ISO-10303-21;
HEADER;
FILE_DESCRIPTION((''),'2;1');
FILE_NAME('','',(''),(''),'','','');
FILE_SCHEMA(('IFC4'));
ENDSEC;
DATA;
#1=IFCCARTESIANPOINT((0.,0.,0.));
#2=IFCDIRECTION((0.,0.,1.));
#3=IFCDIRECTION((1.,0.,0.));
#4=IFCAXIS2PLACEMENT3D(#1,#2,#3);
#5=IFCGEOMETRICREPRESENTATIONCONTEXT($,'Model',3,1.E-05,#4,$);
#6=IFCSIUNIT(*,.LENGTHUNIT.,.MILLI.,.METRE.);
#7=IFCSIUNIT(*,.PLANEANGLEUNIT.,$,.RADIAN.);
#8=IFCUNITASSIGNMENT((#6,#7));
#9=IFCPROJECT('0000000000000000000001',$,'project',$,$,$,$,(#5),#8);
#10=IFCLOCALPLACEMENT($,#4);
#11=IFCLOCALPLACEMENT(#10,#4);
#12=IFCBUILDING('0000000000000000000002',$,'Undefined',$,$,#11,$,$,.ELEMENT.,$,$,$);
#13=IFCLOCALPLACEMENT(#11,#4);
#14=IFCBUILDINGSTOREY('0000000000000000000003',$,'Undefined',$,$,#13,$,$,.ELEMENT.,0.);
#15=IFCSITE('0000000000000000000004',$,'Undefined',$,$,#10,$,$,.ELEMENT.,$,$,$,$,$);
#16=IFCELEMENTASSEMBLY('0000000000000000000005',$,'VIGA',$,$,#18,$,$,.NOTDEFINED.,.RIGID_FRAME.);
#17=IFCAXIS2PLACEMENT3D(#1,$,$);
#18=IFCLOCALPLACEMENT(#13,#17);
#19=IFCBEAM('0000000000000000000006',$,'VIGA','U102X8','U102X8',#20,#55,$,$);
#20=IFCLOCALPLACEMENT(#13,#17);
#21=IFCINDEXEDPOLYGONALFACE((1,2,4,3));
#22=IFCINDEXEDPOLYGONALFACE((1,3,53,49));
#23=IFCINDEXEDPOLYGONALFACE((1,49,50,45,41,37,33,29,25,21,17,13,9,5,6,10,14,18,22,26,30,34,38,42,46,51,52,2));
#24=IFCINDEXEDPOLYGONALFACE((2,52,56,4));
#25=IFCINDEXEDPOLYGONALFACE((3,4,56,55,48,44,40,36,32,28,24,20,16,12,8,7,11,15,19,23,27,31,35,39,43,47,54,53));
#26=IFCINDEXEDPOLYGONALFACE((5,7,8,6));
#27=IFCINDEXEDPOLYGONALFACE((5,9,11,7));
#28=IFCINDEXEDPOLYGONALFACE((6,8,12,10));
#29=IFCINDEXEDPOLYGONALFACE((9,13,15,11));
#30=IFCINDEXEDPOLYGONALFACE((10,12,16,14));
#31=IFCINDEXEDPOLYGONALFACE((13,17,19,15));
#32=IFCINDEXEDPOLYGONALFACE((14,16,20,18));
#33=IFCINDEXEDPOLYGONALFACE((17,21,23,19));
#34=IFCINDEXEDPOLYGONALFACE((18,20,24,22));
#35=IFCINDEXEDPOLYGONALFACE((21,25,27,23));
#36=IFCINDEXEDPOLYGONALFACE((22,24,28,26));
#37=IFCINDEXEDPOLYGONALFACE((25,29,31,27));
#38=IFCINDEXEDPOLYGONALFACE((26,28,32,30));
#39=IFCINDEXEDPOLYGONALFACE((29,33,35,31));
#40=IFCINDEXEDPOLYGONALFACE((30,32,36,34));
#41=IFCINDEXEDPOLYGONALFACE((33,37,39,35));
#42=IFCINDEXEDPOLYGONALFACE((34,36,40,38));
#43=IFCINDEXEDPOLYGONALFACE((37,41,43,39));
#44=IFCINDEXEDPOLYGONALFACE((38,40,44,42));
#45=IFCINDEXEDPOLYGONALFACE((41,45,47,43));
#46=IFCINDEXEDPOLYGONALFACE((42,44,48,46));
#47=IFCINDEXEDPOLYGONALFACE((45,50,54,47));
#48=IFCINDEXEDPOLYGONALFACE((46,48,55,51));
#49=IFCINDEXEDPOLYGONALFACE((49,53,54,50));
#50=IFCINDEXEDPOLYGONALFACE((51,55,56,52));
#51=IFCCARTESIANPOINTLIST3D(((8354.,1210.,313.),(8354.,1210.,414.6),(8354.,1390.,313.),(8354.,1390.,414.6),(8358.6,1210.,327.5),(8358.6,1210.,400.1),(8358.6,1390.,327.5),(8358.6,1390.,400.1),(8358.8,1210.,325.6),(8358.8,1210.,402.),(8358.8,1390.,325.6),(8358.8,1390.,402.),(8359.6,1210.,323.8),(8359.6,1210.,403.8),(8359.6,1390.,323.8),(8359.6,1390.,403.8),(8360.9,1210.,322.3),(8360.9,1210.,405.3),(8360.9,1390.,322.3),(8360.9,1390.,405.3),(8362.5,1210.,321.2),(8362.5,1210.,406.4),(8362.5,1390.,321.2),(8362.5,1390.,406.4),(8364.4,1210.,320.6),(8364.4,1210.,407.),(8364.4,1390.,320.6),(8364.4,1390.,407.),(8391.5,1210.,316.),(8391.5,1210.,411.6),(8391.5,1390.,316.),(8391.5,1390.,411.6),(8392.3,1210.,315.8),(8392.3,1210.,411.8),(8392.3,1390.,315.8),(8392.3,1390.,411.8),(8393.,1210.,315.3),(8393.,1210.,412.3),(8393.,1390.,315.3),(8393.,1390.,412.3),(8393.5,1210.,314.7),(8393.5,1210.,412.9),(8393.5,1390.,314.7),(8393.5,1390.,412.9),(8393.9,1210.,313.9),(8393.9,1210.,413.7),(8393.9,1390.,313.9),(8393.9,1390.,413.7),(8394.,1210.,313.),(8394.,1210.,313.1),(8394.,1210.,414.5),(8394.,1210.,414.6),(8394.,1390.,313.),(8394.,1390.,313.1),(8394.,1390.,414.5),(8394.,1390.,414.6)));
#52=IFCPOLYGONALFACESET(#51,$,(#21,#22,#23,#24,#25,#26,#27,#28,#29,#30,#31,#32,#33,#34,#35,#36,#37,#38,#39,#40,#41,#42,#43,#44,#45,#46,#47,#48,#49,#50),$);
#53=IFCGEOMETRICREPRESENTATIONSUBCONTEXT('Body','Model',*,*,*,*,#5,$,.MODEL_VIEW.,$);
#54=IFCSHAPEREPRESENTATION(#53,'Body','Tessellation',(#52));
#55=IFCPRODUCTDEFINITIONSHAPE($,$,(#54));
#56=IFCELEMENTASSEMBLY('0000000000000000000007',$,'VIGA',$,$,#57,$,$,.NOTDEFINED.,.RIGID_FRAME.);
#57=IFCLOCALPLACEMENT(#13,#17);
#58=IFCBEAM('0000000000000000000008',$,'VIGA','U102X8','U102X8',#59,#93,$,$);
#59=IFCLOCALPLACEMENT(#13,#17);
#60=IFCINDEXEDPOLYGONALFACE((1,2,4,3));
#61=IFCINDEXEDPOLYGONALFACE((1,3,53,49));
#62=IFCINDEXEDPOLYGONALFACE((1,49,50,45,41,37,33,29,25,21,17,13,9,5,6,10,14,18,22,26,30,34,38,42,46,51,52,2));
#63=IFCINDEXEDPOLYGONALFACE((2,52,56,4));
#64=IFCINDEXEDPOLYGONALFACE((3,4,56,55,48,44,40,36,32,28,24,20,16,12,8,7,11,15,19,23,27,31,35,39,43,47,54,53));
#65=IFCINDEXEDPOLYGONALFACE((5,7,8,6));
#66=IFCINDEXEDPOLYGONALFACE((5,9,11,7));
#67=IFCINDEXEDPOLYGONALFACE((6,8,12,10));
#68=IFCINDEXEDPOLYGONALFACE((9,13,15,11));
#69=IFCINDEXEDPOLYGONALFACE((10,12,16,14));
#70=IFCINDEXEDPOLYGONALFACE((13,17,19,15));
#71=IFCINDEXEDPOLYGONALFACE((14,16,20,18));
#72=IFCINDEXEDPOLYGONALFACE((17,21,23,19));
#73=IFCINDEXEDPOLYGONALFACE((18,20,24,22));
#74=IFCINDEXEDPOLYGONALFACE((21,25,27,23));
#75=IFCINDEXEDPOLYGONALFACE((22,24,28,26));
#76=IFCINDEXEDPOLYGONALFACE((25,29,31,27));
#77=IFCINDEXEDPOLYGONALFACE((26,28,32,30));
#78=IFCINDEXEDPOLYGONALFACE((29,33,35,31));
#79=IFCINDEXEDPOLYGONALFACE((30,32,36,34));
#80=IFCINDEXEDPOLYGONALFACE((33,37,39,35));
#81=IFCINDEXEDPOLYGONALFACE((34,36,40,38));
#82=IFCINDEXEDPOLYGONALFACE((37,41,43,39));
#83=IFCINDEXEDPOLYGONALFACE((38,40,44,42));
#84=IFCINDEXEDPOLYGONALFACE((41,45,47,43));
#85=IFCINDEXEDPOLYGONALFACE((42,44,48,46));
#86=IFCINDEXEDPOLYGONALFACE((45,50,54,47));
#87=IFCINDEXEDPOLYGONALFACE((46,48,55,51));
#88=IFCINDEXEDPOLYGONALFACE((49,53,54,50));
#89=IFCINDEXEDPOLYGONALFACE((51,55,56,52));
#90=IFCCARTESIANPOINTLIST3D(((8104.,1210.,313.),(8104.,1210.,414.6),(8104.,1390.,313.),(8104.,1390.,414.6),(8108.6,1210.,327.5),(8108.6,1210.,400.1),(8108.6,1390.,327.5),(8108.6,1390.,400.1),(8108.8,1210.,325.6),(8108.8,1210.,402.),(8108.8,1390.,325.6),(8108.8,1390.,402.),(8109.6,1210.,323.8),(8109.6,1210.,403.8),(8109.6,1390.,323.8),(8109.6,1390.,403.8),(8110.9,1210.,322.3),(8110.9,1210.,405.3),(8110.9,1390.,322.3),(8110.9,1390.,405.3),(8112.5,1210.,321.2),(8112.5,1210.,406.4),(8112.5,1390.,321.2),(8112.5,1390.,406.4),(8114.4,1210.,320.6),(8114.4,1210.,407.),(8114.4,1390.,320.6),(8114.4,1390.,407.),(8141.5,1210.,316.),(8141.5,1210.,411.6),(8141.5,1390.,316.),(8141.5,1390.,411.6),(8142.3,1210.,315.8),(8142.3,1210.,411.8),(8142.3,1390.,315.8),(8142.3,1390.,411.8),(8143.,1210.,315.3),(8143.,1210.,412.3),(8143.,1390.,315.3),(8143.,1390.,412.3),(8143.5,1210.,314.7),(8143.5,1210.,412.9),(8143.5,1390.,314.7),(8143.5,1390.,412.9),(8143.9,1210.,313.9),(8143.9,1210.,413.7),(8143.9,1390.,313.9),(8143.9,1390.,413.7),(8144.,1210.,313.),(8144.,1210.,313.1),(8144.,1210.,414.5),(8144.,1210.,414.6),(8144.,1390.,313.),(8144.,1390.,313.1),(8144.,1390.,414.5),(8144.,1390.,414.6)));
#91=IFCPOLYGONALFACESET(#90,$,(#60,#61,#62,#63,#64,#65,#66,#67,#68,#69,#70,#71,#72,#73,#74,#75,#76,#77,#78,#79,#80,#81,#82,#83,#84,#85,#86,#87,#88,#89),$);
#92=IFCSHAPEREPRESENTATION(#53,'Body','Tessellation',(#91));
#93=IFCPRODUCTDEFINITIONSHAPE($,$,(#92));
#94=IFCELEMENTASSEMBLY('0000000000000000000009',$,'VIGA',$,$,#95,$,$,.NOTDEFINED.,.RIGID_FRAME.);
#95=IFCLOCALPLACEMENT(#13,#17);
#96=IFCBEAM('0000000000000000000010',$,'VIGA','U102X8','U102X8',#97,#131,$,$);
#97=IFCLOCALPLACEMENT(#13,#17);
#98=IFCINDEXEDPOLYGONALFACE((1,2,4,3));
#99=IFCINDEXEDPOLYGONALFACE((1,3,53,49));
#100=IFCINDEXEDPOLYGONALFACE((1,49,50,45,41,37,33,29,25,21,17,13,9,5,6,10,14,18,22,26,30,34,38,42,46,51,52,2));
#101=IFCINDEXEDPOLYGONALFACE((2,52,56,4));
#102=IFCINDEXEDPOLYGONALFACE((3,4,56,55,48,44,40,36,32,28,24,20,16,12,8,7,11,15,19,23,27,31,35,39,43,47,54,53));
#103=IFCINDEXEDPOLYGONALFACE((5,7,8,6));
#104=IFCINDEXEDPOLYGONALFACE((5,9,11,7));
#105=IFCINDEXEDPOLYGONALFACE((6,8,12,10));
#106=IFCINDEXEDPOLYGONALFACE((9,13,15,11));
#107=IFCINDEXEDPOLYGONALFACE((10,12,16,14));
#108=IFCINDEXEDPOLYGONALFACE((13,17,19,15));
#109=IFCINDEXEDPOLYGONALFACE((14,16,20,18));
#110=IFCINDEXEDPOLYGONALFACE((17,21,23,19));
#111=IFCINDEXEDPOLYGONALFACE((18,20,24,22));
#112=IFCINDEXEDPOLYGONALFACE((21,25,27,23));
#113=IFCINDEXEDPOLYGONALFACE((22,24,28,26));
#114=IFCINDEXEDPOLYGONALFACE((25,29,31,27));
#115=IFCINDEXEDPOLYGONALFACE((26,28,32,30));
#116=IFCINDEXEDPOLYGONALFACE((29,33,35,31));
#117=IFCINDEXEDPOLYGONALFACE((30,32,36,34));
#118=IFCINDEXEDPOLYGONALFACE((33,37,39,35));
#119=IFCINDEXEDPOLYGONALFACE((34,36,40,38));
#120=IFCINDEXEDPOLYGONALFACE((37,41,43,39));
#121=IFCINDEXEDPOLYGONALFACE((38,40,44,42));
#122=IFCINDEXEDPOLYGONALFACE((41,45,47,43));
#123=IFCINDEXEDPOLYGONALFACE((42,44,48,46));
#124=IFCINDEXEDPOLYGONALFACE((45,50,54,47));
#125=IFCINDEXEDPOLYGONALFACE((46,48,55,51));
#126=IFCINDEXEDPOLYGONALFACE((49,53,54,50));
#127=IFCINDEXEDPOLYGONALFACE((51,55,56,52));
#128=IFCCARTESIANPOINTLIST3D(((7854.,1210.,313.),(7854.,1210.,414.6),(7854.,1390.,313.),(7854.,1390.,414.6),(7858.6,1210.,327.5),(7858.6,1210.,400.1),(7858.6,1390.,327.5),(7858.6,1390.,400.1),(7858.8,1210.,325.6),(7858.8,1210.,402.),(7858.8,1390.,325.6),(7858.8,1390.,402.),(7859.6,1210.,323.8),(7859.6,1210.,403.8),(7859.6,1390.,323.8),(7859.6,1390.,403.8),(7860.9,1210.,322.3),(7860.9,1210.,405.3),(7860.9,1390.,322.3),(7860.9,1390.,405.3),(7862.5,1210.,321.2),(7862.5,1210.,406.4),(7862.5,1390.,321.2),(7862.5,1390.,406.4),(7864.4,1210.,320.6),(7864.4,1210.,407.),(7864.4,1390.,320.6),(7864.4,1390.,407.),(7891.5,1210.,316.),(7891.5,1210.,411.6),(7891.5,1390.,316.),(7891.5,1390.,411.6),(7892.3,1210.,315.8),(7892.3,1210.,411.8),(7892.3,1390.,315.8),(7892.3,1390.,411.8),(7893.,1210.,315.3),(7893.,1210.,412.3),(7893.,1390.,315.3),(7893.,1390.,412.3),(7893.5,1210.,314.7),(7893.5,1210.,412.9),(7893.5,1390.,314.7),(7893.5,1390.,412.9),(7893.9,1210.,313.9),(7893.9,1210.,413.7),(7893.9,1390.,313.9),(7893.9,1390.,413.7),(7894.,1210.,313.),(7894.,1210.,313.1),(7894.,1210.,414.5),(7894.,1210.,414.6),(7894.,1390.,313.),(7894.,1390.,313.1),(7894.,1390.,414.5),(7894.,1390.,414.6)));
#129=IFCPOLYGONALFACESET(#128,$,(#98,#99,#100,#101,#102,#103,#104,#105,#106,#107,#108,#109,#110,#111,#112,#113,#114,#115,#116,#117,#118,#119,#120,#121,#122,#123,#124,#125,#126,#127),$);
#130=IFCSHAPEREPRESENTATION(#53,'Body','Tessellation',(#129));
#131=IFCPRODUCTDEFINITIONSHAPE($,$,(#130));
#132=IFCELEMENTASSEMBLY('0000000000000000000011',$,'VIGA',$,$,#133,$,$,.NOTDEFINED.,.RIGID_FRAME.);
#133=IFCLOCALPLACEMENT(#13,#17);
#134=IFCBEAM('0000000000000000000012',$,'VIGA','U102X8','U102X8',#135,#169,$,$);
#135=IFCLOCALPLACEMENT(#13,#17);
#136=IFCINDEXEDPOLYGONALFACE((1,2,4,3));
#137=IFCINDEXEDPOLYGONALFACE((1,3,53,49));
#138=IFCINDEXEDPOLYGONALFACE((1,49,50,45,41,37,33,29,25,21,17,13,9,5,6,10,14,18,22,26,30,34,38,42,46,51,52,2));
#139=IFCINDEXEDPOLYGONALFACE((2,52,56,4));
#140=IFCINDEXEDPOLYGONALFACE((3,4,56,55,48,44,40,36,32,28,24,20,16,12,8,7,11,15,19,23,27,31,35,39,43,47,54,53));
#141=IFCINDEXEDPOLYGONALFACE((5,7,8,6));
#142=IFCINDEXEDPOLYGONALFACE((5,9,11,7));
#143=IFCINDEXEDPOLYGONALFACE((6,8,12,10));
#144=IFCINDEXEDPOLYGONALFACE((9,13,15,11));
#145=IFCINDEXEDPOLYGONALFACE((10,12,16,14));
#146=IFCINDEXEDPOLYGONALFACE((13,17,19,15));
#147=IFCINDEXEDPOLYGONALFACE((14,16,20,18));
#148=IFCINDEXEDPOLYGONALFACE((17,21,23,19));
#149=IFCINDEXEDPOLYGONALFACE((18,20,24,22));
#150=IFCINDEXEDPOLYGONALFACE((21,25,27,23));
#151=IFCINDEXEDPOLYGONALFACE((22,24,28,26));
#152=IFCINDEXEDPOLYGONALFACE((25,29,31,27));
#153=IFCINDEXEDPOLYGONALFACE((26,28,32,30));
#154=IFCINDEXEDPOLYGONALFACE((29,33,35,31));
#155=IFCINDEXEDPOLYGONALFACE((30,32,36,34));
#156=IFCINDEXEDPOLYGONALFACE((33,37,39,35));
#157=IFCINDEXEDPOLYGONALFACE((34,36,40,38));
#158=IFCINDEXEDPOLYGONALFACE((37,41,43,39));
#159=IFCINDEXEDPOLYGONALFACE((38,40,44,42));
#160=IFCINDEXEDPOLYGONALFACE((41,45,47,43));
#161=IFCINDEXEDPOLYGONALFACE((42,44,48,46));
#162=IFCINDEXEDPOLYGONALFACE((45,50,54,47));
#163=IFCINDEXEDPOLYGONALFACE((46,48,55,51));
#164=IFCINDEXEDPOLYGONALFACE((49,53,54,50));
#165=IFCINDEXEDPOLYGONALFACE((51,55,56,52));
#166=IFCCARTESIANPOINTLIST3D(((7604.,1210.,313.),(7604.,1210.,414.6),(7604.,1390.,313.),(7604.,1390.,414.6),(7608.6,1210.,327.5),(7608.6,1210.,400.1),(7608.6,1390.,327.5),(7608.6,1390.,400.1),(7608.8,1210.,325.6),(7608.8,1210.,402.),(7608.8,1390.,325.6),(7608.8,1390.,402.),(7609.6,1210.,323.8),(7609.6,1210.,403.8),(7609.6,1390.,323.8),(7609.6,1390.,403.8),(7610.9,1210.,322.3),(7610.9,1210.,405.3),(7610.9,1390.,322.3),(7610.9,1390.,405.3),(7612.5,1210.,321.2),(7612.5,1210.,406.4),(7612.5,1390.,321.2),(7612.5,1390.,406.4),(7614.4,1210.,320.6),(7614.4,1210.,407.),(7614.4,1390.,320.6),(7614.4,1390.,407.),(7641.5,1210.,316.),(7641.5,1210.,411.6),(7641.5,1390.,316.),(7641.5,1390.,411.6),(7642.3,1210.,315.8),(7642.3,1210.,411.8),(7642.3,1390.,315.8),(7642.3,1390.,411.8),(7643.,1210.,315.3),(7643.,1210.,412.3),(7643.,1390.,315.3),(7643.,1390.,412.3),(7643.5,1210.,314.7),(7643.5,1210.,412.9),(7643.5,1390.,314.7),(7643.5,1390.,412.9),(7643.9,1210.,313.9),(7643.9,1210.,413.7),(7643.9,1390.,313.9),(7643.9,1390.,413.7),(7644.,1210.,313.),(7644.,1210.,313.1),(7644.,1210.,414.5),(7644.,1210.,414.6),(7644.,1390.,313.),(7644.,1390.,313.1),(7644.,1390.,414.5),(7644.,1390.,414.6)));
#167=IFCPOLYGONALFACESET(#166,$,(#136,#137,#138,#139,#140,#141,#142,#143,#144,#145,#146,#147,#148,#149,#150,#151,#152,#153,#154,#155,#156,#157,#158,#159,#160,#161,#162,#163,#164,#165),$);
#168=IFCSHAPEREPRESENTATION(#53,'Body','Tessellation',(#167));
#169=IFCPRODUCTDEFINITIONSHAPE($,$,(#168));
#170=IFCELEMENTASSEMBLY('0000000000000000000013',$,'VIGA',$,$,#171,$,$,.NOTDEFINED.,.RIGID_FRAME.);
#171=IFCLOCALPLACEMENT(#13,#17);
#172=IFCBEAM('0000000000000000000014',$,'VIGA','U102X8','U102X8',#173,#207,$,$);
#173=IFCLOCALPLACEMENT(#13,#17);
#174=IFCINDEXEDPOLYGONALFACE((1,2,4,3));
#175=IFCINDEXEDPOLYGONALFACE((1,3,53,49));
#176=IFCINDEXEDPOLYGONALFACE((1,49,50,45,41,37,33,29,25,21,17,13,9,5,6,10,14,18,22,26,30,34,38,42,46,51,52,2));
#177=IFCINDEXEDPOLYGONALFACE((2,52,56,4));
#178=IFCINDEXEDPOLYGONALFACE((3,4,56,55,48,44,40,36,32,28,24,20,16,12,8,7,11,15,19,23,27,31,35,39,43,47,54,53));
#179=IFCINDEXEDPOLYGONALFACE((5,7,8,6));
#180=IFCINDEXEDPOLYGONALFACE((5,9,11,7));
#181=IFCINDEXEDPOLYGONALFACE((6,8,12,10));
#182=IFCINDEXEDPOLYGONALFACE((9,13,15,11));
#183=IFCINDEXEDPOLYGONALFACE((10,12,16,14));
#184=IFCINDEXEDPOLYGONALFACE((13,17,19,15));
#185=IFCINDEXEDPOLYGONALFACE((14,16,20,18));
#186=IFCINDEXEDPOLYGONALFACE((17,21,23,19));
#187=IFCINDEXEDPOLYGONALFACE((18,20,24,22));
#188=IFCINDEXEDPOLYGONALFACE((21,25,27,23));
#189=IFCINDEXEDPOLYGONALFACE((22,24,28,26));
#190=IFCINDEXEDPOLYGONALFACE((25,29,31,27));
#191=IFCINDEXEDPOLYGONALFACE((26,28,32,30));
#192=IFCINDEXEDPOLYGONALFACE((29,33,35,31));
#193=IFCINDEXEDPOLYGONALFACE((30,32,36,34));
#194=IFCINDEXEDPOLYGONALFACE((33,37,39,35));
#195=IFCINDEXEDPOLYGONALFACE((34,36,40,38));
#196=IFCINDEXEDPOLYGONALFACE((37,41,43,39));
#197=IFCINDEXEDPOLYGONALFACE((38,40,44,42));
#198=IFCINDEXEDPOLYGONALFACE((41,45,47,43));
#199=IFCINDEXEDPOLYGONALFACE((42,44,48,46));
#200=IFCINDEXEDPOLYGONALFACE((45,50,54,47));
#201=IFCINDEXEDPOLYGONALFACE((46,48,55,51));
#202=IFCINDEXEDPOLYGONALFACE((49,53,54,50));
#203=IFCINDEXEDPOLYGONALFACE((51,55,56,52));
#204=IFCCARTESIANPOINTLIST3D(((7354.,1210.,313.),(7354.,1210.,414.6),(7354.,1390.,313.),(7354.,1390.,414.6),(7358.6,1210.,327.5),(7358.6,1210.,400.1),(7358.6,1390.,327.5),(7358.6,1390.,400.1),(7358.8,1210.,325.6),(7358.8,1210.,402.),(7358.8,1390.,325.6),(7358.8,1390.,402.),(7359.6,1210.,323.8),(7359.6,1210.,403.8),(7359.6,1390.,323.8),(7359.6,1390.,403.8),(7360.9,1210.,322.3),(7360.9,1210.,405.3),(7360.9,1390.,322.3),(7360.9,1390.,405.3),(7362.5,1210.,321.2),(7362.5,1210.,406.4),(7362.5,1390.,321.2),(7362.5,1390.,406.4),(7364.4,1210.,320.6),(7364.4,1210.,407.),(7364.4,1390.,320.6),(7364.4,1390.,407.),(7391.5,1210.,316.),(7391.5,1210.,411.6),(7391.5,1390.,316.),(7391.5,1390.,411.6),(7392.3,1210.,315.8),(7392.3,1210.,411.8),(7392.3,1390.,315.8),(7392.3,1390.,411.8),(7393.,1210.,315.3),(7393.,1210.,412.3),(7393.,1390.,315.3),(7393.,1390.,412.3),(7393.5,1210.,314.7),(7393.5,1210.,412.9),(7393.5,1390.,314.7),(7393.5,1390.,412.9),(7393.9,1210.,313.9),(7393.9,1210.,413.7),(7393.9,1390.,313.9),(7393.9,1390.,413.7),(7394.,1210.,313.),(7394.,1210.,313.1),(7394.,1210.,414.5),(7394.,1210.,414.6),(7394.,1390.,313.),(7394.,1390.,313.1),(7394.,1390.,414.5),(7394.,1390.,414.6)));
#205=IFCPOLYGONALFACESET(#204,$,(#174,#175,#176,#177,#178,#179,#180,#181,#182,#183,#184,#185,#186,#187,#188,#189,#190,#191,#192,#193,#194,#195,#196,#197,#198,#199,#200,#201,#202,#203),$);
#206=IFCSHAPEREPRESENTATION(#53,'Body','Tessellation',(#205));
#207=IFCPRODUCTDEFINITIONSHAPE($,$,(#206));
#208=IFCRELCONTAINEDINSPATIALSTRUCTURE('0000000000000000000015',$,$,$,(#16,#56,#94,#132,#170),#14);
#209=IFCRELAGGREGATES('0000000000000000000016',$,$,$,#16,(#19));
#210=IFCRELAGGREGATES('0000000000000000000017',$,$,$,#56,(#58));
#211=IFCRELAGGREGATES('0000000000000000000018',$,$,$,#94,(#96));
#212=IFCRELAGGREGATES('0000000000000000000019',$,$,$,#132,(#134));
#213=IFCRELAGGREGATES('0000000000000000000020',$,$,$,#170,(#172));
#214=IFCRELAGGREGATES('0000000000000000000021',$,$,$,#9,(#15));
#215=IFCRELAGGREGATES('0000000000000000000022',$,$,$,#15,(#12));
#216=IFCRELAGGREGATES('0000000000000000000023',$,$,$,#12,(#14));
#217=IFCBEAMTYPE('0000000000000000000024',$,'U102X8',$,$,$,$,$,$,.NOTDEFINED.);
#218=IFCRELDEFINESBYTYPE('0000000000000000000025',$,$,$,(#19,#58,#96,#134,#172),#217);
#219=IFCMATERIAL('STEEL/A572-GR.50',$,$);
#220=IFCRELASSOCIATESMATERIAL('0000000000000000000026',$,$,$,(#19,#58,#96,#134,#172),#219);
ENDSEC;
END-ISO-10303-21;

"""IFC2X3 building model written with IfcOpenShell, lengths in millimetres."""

from ifc_helpers import new_model, si_unit, frame, origin_with_axes, origin_2d_with_axis, place, context, subcontext, project, spatial, u_section, extrude, material, type_object, element, aggregate, save


model = new_model("IFC2X3")

# Units and contexts
model_context = context("Model", 3, precision=1e-05, world=origin_with_axes())
body_context = subcontext(model_context, "Body", "Model", "MODEL_VIEW")
ifc_project = project(units=[si_unit("LENGTHUNIT", "METRE", prefix="MILLI"), si_unit("PLANEANGLEUNIT", "RADIAN")], contexts=[model_context])

# Site, building, storey
site_placement = place(None, origin_with_axes())
site = spatial("IfcSite", under=ifc_project, at=site_placement, Name="Undefined", CompositionType="ELEMENT")
building_placement = place(site_placement, origin_with_axes())
building = spatial("IfcBuilding", under=site, at=building_placement, Name="Undefined", CompositionType="ELEMENT")
storey_placement = place(building_placement, origin_with_axes())
storey = spatial("IfcBuildingStorey", under=building, at=storey_placement, Name="Undefined", CompositionType="ELEMENT", Elevation=0.0)

# Element assemblies, beams
ifc_material_1 = material(Name="STEEL/A572-GR.50")
beam_type_1 = type_object("IfcBeamType", Name="U102X8", PredefinedType="NOTDEFINED")
assembly_1_placement = place(storey_placement, origin_with_axes())
assembly_1 = element("IfcElementAssembly", 1, at=assembly_1_placement, inside=storey, Name="VIGA", AssemblyPlace="NOTDEFINED", PredefinedType="RIGID_FRAME")
beam_1_placement = place(assembly_1_placement, frame((8374.0, 1210.0, 363.8), z_axis=(0.0, 0.0, 1.0), x_axis=(0.0, 1.0, 0.0)))
beam_1 = element("IfcBeam", 2, at=beam_1_placement, type_object=beam_type_1, material=ifc_material_1, Name="VIGA", Description="U102X8", ObjectType="U102X8", context=body_context, shape_type="SweptSolid", body=[
    extrude(u_section(Depth=101.6, FlangeWidth=40.0, WebThickness=4.6, FlangeThickness=6.0, FilletRadius=7.0, EdgeRadius=3.0, FlangeSlope=0.16839, at=origin_2d_with_axis()), frame((180.0, 0.0, 0.0), z_axis=(-1.0, 0.0, 0.0), x_axis=(0.0, -1.0, 0.0)), (0.0, 0.0, 1.0), 180.0),
])
aggregate(assembly_1, [beam_1])
assembly_2_placement = place(storey_placement, origin_with_axes())
assembly_2 = element("IfcElementAssembly", 3, at=assembly_2_placement, inside=storey, Name="VIGA", AssemblyPlace="NOTDEFINED", PredefinedType="RIGID_FRAME")
beam_2_placement = place(assembly_2_placement, frame((8124.0, 1210.0, 363.8), z_axis=(0.0, 0.0, 1.0), x_axis=(0.0, 1.0, 0.0)))
beam_2 = element("IfcBeam", 4, at=beam_2_placement, type_object=beam_type_1, material=ifc_material_1, Name="VIGA", Description="U102X8", ObjectType="U102X8", context=body_context, shape_type="SweptSolid", body=[
    extrude(u_section(Depth=101.6, FlangeWidth=40.0, WebThickness=4.6, FlangeThickness=6.0, FilletRadius=7.0, EdgeRadius=3.0, FlangeSlope=0.16839, at=origin_2d_with_axis()), frame((180.0, 0.0, 0.0), z_axis=(-1.0, 0.0, 0.0), x_axis=(0.0, -1.0, 0.0)), (0.0, 0.0, 1.0), 180.0),
])
aggregate(assembly_2, [beam_2])
assembly_3_placement = place(storey_placement, origin_with_axes())
assembly_3 = element("IfcElementAssembly", 5, at=assembly_3_placement, inside=storey, Name="VIGA", AssemblyPlace="NOTDEFINED", PredefinedType="RIGID_FRAME")
beam_3_placement = place(assembly_3_placement, frame((7874.0, 1210.0, 363.8), z_axis=(0.0, 0.0, 1.0), x_axis=(0.0, 1.0, 0.0)))
beam_3 = element("IfcBeam", 6, at=beam_3_placement, type_object=beam_type_1, material=ifc_material_1, Name="VIGA", Description="U102X8", ObjectType="U102X8", context=body_context, shape_type="SweptSolid", body=[
    extrude(u_section(Depth=101.6, FlangeWidth=40.0, WebThickness=4.6, FlangeThickness=6.0, FilletRadius=7.0, EdgeRadius=3.0, FlangeSlope=0.16839, at=origin_2d_with_axis()), frame((180.0, 0.0, 0.0), z_axis=(-1.0, 0.0, 0.0), x_axis=(0.0, -1.0, 0.0)), (0.0, 0.0, 1.0), 180.0),
])
aggregate(assembly_3, [beam_3])
assembly_4_placement = place(storey_placement, origin_with_axes())
assembly_4 = element("IfcElementAssembly", 7, at=assembly_4_placement, inside=storey, Name="VIGA", AssemblyPlace="NOTDEFINED", PredefinedType="RIGID_FRAME")
beam_4_placement = place(assembly_4_placement, frame((7624.0, 1210.0, 363.8), z_axis=(0.0, 0.0, 1.0), x_axis=(0.0, 1.0, 0.0)))
beam_4 = element("IfcBeam", 8, at=beam_4_placement, type_object=beam_type_1, material=ifc_material_1, Name="VIGA", Description="U102X8", ObjectType="U102X8", context=body_context, shape_type="SweptSolid", body=[
    extrude(u_section(Depth=101.6, FlangeWidth=40.0, WebThickness=4.6, FlangeThickness=6.0, FilletRadius=7.0, EdgeRadius=3.0, FlangeSlope=0.16839, at=origin_2d_with_axis()), frame((180.0, 0.0, 0.0), z_axis=(-1.0, 0.0, 0.0), x_axis=(0.0, -1.0, 0.0)), (0.0, 0.0, 1.0), 180.0),
])
aggregate(assembly_4, [beam_4])
assembly_5_placement = place(storey_placement, origin_with_axes())
assembly_5 = element("IfcElementAssembly", 9, at=assembly_5_placement, inside=storey, Name="VIGA", AssemblyPlace="NOTDEFINED", PredefinedType="RIGID_FRAME")
beam_5_placement = place(assembly_5_placement, frame((7374.0, 1210.0, 363.8), z_axis=(0.0, 0.0, 1.0), x_axis=(0.0, 1.0, 0.0)))
beam_5 = element("IfcBeam", 10, at=beam_5_placement, type_object=beam_type_1, material=ifc_material_1, Name="VIGA", Description="U102X8", ObjectType="U102X8", context=body_context, shape_type="SweptSolid", body=[
    extrude(u_section(Depth=101.6, FlangeWidth=40.0, WebThickness=4.6, FlangeThickness=6.0, FilletRadius=7.0, EdgeRadius=3.0, FlangeSlope=0.16839, at=origin_2d_with_axis()), frame((180.0, 0.0, 0.0), z_axis=(-1.0, 0.0, 0.0), x_axis=(0.0, -1.0, 0.0)), (0.0, 0.0, 1.0), 180.0),
])
aggregate(assembly_5, [beam_5])

save(model, "model.ifc")
